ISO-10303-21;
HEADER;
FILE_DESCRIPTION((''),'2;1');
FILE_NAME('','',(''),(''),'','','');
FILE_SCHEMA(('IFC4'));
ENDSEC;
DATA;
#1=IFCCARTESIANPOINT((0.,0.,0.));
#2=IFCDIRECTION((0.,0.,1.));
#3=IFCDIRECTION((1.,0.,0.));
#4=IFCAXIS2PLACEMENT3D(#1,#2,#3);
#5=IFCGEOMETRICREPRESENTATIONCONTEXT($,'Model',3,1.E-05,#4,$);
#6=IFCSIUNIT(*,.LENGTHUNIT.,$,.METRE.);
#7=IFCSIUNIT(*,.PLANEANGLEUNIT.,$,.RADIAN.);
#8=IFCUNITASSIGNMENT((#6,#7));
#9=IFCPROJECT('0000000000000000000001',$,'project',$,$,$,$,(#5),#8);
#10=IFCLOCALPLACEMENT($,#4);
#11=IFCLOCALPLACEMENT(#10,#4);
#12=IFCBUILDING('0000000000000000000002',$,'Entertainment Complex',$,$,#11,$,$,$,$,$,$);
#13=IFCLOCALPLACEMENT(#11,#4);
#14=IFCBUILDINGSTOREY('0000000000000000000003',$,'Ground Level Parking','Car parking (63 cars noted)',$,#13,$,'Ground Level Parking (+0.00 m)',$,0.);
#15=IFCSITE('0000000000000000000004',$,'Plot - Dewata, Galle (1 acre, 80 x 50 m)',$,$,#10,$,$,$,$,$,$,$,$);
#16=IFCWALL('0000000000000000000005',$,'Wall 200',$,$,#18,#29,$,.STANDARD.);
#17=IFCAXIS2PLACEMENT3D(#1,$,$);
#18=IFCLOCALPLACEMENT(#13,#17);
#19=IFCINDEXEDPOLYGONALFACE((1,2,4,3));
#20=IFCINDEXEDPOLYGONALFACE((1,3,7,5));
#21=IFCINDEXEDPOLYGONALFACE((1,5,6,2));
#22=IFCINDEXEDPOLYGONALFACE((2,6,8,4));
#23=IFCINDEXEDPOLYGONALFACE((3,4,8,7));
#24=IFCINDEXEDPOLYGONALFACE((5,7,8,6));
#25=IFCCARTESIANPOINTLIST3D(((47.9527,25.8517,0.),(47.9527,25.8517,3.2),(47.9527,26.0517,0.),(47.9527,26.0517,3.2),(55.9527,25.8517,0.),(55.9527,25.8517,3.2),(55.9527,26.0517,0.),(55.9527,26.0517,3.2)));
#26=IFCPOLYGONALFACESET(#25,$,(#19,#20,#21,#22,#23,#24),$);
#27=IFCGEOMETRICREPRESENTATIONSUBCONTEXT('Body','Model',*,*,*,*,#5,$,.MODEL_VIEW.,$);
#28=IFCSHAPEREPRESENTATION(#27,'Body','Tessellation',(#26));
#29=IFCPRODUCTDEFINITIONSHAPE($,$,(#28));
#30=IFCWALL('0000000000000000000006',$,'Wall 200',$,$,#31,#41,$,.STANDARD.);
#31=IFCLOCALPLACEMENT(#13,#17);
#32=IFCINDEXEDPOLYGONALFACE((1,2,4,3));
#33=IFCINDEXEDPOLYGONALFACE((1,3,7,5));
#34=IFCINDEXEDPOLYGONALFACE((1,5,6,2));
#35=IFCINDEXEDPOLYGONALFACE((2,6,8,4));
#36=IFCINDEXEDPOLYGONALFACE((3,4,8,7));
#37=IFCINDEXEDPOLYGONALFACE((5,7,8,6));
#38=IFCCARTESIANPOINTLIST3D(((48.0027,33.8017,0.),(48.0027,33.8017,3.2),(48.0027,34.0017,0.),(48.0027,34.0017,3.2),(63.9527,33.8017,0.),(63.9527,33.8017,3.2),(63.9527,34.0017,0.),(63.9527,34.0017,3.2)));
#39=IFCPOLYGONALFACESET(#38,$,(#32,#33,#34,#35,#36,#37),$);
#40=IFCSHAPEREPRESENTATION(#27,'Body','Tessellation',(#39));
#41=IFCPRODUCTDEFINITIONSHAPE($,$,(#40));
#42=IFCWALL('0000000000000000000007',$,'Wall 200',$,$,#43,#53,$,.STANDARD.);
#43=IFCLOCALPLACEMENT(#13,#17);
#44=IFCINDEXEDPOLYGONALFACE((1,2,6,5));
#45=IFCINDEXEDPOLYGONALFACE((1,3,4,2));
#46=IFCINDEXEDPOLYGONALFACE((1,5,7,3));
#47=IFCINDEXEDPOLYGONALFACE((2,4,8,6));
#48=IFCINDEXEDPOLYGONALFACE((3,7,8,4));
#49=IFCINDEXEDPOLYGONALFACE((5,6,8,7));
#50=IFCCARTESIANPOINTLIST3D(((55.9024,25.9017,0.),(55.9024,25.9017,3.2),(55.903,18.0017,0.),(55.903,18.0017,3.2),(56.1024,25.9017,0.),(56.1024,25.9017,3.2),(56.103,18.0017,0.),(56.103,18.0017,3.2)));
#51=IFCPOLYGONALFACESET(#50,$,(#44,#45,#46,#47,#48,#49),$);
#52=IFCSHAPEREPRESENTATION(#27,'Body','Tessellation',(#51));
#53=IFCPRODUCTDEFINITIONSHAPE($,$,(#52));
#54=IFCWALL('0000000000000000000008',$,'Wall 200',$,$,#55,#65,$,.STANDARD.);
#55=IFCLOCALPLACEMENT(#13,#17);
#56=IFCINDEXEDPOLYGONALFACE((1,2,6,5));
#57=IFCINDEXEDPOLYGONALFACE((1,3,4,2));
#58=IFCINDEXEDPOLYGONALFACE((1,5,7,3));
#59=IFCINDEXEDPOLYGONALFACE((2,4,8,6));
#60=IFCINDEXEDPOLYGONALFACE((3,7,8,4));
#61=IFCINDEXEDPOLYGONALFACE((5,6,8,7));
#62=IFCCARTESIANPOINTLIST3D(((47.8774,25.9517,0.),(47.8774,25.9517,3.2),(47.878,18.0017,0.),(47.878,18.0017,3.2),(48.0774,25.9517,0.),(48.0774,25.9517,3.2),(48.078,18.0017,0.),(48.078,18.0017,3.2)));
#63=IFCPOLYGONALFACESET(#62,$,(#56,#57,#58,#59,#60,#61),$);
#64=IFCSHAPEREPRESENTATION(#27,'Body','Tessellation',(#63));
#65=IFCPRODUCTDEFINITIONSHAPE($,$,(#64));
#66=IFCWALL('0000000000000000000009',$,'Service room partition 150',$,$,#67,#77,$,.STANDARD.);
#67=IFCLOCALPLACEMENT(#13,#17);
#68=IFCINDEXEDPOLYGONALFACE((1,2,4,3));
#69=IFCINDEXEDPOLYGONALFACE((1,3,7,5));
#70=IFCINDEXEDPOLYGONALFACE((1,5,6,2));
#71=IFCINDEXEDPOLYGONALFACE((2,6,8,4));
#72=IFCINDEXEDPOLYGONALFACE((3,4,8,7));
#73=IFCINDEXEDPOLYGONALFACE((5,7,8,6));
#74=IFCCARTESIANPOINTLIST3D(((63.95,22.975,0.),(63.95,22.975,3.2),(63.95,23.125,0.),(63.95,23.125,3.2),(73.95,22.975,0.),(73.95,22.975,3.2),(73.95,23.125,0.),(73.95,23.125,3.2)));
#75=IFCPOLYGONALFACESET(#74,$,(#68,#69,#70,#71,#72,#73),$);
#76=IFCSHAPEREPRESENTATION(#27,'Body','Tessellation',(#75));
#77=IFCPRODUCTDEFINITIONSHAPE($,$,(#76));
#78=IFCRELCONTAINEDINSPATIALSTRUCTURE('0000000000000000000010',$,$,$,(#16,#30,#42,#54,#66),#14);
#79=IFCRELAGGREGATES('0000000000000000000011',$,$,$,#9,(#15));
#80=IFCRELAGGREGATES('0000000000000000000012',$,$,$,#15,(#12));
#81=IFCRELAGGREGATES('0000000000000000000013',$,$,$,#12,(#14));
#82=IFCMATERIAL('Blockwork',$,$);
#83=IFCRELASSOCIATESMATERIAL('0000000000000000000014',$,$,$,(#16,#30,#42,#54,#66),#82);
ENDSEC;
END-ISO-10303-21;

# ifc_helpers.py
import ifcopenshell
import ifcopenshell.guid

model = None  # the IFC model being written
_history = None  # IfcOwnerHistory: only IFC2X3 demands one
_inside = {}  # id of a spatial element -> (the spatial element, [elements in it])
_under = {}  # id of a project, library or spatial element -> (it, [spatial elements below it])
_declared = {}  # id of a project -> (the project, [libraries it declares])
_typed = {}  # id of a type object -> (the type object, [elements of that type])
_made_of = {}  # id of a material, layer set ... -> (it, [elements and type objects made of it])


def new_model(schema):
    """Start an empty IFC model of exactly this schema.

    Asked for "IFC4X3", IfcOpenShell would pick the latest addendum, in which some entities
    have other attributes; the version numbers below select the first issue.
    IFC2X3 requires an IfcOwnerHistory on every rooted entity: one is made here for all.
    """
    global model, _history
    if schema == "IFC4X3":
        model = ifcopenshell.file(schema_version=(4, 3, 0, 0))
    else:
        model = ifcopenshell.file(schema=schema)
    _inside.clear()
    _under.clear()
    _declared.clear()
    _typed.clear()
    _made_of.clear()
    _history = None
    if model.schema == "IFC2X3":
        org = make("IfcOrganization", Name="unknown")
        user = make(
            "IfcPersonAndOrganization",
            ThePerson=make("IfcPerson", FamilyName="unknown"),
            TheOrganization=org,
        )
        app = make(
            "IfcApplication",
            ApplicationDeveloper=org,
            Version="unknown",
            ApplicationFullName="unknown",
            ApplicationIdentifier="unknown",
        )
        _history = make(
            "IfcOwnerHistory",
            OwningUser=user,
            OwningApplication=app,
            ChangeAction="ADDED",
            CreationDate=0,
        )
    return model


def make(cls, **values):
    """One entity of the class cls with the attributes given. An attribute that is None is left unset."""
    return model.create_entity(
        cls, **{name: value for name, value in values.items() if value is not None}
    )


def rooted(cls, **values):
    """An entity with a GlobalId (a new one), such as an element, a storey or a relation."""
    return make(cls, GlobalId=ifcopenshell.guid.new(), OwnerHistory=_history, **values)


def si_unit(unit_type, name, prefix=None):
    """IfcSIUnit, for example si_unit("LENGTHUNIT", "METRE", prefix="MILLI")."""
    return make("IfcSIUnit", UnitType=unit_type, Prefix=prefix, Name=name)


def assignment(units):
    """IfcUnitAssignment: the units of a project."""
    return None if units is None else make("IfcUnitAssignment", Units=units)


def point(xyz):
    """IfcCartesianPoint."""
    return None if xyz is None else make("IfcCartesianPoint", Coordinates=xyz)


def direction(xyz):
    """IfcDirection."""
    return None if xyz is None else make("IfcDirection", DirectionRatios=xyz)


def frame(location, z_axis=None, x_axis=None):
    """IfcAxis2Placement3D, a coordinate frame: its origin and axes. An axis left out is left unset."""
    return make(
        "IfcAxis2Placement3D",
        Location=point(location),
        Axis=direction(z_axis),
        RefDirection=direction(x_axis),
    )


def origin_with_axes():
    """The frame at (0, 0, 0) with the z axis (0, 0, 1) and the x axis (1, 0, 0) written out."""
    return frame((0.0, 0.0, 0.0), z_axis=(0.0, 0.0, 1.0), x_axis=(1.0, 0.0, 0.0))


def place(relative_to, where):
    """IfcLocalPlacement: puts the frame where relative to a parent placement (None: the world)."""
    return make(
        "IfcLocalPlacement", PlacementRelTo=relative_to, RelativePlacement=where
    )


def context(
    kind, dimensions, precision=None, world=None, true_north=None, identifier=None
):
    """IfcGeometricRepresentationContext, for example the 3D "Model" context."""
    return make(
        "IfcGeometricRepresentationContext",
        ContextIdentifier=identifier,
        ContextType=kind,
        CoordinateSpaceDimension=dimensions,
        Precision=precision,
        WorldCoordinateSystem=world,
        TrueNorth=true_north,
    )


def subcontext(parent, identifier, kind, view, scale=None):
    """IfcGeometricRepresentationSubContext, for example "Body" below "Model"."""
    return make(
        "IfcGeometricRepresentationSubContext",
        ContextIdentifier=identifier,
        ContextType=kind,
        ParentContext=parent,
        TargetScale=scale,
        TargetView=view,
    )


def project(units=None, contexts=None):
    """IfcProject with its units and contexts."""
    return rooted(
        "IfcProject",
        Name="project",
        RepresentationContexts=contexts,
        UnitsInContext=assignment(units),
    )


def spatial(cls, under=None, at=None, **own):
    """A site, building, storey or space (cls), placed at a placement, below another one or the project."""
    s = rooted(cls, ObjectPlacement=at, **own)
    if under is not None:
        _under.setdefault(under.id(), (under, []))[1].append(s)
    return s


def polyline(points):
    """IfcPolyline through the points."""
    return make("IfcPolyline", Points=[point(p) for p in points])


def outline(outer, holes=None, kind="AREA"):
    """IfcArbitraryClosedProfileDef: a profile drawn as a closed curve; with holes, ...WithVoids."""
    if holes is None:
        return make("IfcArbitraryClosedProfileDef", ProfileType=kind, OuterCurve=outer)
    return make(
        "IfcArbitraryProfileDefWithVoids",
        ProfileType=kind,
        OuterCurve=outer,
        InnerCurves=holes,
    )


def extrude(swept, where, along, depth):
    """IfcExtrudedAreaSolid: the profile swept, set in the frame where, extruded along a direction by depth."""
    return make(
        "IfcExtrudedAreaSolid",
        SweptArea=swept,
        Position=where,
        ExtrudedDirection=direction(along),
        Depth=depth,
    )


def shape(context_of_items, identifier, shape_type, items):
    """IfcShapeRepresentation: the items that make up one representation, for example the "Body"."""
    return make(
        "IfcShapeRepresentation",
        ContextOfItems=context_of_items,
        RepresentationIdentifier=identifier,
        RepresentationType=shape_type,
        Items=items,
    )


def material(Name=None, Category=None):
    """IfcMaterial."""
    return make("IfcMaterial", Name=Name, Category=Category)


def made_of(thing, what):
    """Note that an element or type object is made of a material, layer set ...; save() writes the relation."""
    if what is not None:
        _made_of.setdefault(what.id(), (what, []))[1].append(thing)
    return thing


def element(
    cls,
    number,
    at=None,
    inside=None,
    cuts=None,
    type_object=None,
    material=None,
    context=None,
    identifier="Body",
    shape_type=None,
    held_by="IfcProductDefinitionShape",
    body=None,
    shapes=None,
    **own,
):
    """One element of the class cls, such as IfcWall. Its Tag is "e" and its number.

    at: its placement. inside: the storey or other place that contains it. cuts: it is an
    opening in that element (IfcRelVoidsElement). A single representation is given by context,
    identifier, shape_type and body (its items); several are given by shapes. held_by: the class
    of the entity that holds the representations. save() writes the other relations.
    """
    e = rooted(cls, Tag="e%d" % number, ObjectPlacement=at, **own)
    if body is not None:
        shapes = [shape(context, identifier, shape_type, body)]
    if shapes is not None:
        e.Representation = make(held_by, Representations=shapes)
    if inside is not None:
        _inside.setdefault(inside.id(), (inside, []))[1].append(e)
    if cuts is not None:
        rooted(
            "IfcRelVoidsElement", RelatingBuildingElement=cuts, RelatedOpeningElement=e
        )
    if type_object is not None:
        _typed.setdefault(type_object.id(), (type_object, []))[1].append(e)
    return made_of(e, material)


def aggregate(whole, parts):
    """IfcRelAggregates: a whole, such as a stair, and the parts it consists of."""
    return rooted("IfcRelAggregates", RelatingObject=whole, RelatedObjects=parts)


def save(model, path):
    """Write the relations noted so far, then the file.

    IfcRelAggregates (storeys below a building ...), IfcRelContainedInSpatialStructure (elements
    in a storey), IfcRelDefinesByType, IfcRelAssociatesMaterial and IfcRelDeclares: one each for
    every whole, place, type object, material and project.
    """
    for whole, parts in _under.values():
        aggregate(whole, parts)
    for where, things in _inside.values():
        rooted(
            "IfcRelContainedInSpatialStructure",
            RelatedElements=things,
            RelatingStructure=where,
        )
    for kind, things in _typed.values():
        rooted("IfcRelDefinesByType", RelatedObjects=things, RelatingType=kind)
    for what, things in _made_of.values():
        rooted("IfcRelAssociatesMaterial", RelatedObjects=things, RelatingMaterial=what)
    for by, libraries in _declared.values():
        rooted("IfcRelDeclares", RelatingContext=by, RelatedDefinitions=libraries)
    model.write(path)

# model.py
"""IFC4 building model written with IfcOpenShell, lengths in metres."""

from ifc_helpers import new_model, si_unit, frame, origin_with_axes, place, context, subcontext, project, spatial, polyline, outline, extrude, material, element, save


model = new_model("IFC4")

# Units and contexts
model_context = context("Model", 3, precision=1e-05, world=origin_with_axes())
body_context = subcontext(model_context, "Body", "Model", "MODEL_VIEW")
ifc_project = project(units=[si_unit("LENGTHUNIT", "METRE"), si_unit("PLANEANGLEUNIT", "RADIAN")], contexts=[model_context])

# Site, building, storey
site_placement = place(None, origin_with_axes())
site = spatial("IfcSite", under=ifc_project, at=site_placement, Name="Plot - Dewata, Galle (1 acre, 80 x 50 m)")
building_placement = place(site_placement, origin_with_axes())
building = spatial("IfcBuilding", under=site, at=building_placement, Name="Entertainment Complex")
storey_placement = place(building_placement, origin_with_axes())
storey = spatial("IfcBuildingStorey", under=building, at=storey_placement, Name="Ground Level Parking", Description="Car parking (63 cars noted)", LongName="Ground Level Parking (+0.00 m)", Elevation=0.0)

# Walls
ifc_material_1 = material(Name="Blockwork")
for number, where, z_axis, x_axis, name in (
    (1, (47.9527, 25.9517, 0.0), (0.0, 0.0, 1.0), (1.0, 0.0, 0.0), "Wall 200"),
):
    element("IfcWall", number, at=place(storey_placement, frame(where, z_axis=z_axis, x_axis=x_axis)), inside=storey, material=ifc_material_1, Name=name, PredefinedType="STANDARD", context=body_context, shape_type="SweptSolid", body=[
        extrude(outline(polyline([(0.0, -0.1), (8.0, -0.1), (8.0, 0.1), (0.0, 0.1), (0.0, -0.1)])), origin_with_axes(), (0.0, 0.0, 1.0), 3.2),
    ])
wall_1_placement = place(storey_placement, frame((48.0027, 33.9017, 0.0), z_axis=(0.0, 0.0, 1.0), x_axis=(1.0, 0.0, 0.0)))
element("IfcWall", 2, at=wall_1_placement, inside=storey, material=ifc_material_1, Name="Wall 200", PredefinedType="STANDARD", context=body_context, shape_type="SweptSolid", body=[
    extrude(outline(polyline([(0.0, -0.1), (15.95, -0.1), (15.95, 0.1), (0.0, 0.1), (0.0, -0.1)])), origin_with_axes(), (0.0, 0.0, 1.0), 3.2),
])
wall_2_placement = place(storey_placement, frame((56.003, 18.0017, 0.0), z_axis=(0.0, 0.0, 1.0), x_axis=(-0.000076, 1.0, 0.0)))
element("IfcWall", 3, at=wall_2_placement, inside=storey, material=ifc_material_1, Name="Wall 200", PredefinedType="STANDARD", context=body_context, shape_type="SweptSolid", body=[
    extrude(outline(polyline([(0.0, -0.1), (7.9, -0.1), (7.9, 0.1), (0.0, 0.1), (0.0, -0.1)])), origin_with_axes(), (0.0, 0.0, 1.0), 3.2),
])
wall_3_placement = place(storey_placement, frame((47.978, 18.0017, 0.0), z_axis=(0.0, 0.0, 1.0), x_axis=(-0.000075, 1.0, 0.0)))
element("IfcWall", 4, at=wall_3_placement, inside=storey, material=ifc_material_1, Name="Wall 200", PredefinedType="STANDARD", context=body_context, shape_type="SweptSolid", body=[
    extrude(outline(polyline([(0.0, -0.1), (7.95, -0.1), (7.95, 0.1), (0.0, 0.1), (0.0, -0.1)])), origin_with_axes(), (0.0, 0.0, 1.0), 3.2),
])
wall_4_placement = place(storey_placement, frame((63.95, 23.05, 0.0), z_axis=(0.0, 0.0, 1.0), x_axis=(1.0, 0.0, 0.0)))
element("IfcWall", 5, at=wall_4_placement, inside=storey, material=ifc_material_1, Name="Service room partition 150", PredefinedType="STANDARD", context=body_context, shape_type="SweptSolid", body=[
    extrude(outline(polyline([(0.0, -0.075), (10.0, -0.075), (10.0, 0.075), (0.0, 0.075), (0.0, -0.075)])), origin_with_axes(), (0.0, 0.0, 1.0), 3.2),
])

save(model, "model.ifc")
